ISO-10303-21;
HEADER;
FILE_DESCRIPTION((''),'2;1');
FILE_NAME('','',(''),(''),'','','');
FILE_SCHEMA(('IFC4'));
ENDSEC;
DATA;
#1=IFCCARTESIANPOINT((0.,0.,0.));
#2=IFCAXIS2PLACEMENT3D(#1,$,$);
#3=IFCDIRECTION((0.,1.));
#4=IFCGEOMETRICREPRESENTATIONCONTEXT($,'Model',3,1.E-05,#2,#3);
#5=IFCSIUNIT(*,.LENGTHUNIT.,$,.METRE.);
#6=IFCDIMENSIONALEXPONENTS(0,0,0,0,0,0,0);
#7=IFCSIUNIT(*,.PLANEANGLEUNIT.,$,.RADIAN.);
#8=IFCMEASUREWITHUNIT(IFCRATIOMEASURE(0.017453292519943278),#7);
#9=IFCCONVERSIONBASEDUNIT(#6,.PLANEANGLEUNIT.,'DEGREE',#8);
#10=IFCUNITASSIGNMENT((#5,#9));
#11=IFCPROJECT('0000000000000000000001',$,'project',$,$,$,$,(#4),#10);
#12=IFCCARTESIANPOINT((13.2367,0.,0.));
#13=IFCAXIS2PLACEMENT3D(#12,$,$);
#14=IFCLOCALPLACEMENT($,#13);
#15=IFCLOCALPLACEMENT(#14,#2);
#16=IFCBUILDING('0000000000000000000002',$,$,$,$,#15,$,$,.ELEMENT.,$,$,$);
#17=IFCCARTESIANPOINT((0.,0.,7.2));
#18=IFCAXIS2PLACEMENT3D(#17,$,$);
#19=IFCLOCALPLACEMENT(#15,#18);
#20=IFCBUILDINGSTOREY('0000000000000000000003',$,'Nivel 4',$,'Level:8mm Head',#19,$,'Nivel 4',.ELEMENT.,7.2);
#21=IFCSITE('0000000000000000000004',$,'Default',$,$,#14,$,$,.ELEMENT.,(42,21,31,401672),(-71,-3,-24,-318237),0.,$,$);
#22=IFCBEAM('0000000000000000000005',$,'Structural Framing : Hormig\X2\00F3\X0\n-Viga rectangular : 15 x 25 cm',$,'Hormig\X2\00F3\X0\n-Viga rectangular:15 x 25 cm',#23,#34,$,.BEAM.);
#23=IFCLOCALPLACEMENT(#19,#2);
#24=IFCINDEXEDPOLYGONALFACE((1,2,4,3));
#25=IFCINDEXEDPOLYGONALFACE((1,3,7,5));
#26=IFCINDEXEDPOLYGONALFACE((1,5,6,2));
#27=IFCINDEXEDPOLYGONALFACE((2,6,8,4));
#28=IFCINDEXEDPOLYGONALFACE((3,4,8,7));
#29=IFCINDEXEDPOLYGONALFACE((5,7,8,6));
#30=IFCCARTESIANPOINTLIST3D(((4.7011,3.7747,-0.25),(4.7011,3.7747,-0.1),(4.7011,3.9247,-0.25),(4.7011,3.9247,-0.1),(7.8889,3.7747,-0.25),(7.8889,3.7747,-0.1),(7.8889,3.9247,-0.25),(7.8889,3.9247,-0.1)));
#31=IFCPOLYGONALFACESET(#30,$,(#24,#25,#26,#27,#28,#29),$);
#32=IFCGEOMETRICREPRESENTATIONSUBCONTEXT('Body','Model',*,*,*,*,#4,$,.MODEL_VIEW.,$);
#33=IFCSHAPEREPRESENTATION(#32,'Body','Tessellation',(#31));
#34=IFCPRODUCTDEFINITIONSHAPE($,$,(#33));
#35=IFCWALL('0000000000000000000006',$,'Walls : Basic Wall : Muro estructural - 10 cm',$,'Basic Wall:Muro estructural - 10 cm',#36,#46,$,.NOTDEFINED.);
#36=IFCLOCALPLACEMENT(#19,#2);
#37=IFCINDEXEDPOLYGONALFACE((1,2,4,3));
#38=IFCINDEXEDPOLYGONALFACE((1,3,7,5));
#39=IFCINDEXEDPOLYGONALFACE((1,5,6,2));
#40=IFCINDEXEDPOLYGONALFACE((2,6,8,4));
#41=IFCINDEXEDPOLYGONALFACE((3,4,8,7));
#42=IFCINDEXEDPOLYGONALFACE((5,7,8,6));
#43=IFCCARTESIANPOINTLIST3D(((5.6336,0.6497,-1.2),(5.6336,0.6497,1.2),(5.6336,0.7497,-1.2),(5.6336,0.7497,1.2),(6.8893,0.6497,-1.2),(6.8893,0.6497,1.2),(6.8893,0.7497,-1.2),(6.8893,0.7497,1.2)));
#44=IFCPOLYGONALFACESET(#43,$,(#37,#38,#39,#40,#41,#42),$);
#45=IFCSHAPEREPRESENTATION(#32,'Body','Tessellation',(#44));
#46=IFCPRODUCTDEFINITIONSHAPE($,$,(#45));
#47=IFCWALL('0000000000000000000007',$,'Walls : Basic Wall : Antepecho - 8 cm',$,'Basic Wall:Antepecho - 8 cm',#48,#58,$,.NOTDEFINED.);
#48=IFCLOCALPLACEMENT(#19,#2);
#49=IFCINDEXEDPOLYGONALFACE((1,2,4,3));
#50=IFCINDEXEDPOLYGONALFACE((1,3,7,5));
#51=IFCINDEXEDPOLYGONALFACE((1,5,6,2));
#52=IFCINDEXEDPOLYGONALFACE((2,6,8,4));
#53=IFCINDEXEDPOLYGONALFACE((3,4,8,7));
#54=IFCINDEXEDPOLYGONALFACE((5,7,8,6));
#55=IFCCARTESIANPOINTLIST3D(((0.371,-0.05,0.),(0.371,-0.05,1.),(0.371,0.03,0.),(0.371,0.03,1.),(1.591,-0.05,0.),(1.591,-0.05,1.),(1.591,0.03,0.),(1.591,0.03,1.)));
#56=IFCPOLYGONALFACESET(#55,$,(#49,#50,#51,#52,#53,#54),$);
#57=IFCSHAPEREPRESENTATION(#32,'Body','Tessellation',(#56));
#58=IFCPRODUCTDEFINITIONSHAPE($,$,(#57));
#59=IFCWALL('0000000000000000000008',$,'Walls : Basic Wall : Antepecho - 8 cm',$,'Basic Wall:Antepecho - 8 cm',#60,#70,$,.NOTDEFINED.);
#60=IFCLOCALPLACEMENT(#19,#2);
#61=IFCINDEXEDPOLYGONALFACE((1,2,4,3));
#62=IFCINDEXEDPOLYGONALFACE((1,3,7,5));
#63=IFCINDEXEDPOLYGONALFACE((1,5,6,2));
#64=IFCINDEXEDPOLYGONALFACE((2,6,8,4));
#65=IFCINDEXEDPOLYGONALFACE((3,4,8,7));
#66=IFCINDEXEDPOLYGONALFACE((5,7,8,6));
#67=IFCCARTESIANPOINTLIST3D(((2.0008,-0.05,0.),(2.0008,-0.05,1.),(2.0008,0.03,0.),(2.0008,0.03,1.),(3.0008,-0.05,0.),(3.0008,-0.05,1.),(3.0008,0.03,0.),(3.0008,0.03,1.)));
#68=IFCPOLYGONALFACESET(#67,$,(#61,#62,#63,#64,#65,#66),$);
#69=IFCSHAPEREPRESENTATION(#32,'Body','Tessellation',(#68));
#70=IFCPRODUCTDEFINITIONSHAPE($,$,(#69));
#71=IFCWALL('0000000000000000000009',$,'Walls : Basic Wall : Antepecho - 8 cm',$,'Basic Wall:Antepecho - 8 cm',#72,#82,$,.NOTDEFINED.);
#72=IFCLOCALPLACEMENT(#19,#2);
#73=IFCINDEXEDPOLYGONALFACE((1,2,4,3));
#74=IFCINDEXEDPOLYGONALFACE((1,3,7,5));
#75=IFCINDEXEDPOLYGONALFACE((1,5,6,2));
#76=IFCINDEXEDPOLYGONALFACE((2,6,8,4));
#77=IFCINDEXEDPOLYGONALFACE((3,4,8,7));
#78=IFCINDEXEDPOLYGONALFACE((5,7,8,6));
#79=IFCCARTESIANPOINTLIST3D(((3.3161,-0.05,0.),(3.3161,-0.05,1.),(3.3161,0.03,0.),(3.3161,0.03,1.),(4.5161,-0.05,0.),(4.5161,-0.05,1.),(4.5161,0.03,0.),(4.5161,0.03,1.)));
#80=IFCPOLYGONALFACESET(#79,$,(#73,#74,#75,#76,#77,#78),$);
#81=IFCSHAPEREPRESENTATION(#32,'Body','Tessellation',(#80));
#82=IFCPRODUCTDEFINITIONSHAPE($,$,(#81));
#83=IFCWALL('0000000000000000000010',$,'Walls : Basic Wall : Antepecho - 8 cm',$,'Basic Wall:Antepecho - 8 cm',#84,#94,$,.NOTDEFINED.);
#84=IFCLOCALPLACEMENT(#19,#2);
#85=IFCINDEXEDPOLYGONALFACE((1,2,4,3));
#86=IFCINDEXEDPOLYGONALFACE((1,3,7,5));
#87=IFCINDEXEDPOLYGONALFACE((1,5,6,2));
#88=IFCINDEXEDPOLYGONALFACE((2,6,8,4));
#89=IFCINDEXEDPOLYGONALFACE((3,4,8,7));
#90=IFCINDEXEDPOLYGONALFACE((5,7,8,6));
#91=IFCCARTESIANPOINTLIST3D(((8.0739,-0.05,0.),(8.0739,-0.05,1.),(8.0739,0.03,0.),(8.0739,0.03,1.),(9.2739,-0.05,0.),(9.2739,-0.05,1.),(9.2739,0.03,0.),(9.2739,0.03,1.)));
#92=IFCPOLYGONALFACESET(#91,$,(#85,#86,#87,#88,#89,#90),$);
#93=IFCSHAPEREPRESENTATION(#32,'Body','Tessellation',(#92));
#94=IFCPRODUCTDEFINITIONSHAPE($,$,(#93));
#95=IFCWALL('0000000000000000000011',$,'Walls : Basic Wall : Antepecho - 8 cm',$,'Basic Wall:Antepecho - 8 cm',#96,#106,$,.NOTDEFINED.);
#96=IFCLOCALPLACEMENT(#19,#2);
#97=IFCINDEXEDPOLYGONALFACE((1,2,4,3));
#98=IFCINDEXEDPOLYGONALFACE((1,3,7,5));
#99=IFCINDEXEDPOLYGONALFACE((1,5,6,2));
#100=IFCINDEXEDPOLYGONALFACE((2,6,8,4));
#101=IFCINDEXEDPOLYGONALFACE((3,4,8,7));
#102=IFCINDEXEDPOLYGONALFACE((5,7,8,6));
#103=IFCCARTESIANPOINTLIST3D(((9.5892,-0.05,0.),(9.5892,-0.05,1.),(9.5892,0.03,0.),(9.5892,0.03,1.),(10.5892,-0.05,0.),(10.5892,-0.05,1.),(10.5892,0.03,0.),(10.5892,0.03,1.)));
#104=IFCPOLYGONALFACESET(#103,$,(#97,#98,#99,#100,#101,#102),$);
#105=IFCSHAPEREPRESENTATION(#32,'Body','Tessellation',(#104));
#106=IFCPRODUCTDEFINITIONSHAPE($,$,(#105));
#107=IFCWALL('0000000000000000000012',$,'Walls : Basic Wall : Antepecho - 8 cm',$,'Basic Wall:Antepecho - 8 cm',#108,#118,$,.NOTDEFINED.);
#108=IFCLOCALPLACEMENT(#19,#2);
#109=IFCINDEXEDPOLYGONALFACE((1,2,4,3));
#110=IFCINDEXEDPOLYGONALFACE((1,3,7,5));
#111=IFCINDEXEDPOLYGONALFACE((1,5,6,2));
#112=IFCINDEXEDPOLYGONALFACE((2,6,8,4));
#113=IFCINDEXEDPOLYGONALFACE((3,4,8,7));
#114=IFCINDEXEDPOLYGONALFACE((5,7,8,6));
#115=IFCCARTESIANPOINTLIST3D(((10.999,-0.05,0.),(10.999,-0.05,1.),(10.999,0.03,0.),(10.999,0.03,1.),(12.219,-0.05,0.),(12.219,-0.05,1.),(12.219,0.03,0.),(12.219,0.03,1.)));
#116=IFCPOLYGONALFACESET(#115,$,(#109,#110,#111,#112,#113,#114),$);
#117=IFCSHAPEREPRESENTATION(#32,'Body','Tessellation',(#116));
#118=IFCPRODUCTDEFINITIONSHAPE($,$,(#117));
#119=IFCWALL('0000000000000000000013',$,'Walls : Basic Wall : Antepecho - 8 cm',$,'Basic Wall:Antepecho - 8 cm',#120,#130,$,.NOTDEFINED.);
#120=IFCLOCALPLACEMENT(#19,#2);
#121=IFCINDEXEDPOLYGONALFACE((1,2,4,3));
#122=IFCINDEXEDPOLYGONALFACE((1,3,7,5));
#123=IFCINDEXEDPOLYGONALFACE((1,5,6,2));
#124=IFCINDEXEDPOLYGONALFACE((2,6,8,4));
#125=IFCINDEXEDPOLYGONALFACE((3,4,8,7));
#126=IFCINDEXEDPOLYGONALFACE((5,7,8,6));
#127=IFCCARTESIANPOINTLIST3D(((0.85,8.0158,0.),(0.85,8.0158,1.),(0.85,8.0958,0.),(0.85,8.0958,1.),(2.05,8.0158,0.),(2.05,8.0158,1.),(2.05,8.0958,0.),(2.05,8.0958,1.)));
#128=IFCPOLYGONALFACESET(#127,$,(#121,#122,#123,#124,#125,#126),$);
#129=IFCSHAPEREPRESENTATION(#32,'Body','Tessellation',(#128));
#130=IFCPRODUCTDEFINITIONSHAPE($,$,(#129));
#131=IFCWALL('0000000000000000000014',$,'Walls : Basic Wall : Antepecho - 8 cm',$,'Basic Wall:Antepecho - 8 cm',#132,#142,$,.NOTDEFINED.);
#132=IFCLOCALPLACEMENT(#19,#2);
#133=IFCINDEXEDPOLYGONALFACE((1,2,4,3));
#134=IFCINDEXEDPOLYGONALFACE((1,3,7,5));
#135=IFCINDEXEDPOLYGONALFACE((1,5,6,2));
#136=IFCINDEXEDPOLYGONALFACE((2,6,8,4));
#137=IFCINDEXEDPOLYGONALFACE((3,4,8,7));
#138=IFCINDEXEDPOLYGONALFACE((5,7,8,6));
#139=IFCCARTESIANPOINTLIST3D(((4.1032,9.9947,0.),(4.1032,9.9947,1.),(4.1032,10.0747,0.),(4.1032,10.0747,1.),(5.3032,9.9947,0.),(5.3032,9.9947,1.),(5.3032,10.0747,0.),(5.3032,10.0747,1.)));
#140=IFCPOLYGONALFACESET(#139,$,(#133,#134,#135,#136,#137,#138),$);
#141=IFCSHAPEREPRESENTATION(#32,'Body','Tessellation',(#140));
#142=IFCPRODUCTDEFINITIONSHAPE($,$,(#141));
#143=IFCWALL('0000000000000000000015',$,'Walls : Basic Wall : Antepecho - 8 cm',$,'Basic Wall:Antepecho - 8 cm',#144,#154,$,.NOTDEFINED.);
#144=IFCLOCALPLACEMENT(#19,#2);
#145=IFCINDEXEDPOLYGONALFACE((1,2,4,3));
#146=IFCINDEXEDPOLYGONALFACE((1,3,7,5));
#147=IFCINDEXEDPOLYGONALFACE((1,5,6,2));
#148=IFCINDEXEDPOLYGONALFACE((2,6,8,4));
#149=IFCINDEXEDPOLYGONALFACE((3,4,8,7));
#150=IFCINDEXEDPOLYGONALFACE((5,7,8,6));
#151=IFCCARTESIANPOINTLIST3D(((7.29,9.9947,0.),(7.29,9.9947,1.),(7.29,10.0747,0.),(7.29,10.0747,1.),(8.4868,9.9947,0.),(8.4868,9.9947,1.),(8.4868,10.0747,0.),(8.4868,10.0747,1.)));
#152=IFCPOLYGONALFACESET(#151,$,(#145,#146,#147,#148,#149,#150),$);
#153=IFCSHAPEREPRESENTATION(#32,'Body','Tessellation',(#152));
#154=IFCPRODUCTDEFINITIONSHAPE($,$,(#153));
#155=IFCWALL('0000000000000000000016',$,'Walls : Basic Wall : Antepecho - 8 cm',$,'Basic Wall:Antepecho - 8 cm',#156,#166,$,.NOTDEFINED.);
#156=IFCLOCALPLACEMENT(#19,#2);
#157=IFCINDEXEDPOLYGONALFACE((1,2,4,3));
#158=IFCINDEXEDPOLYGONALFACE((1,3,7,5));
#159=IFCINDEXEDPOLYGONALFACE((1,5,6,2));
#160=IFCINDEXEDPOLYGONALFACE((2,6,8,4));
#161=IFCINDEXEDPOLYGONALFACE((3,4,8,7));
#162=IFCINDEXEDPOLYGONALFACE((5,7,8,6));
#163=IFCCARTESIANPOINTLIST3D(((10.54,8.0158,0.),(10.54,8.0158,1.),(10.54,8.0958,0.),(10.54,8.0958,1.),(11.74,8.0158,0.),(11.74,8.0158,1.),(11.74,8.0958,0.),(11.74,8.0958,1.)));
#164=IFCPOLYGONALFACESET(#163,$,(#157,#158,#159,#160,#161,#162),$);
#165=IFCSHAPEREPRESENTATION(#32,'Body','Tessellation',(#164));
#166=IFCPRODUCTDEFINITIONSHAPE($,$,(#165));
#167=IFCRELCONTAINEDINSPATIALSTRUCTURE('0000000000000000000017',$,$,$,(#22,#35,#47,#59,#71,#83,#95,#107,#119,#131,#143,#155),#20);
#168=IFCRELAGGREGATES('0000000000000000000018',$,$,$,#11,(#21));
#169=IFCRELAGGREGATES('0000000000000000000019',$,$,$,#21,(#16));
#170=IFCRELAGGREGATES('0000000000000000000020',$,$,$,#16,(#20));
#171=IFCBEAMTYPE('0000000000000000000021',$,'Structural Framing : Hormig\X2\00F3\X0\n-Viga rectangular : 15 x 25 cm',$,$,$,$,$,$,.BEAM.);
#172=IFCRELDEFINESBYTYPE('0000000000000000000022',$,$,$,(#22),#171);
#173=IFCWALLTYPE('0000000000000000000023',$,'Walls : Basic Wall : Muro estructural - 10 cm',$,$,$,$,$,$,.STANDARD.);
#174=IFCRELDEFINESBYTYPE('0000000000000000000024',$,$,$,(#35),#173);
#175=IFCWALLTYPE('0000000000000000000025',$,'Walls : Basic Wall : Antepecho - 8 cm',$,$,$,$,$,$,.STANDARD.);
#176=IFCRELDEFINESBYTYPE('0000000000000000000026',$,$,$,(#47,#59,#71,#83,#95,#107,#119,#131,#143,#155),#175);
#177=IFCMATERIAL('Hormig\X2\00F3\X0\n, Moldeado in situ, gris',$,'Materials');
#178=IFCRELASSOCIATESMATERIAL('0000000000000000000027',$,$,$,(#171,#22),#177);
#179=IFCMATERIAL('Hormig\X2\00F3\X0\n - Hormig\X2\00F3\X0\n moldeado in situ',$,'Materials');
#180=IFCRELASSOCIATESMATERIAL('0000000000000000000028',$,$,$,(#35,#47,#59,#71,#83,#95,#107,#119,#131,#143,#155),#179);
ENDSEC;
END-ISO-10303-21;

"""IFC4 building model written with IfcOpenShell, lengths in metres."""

from ifc_helpers import new_model, entity, si_unit, converted_unit, direction, frame, origin, place, context, subcontext, project, spatial, indexed_curve, outline, extrude, source, transform, mapped, material, type_object, type_shapes, element, save


model = new_model("IFC4")

# Units and contexts
model_context = context("Model", 3, precision=1e-05, world=origin(), true_north=direction((0.0, 1.0)))
body_context = subcontext(model_context, "Body", "Model", "MODEL_VIEW")
ifc_project = project(units=[si_unit("LENGTHUNIT", "METRE"), converted_unit("PLANEANGLEUNIT", "DEGREE", entity("IfcRatioMeasure", 0.017453292519943278), si_unit("PLANEANGLEUNIT", "RADIAN"), dimensions=[0, 0, 0, 0, 0, 0, 0])], contexts=[model_context])

# Site, building, storey
site_placement = place(None, frame((13.2367, 0.0, 0.0)))
site = spatial("IfcSite", under=ifc_project, at=site_placement, Name="Default", CompositionType="ELEMENT", RefLatitude=(42, 21, 31, 401672), RefLongitude=(-71, -3, -24, -318237), RefElevation=0.0)
building_placement = place(site_placement, origin())
building = spatial("IfcBuilding", under=site, at=building_placement, CompositionType="ELEMENT")
storey_placement = place(building_placement, frame((0.0, 0.0, 7.2)))
storey = spatial("IfcBuildingStorey", under=building, at=storey_placement, Name="Nivel 4", ObjectType="Level:8mm Head", LongName="Nivel 4", CompositionType="ELEMENT", Elevation=7.2)

# Beam
ifc_material_1 = material(Name="Hormigón, Moldeado in situ, gris", Category="Materials")
beam_type_1 = type_object("IfcBeamType", Name="Structural Framing : Hormigón-Viga rectangular : 15 x 25 cm", PredefinedType="BEAM", material=ifc_material_1)
shared_shape_1 = source(origin(), body_context, "Body", "SweptSolid", [
    extrude(outline(indexed_curve([(-0.075, -0.075), (0.075, -0.075), (0.075, 0.075), (-0.075, 0.075), (-0.075, -0.075)], self_intersect=False)), frame((4.7011, 3.8497, 7.025), z_axis=(1.0, 0.0, 0.0), x_axis=(0.0, 0.0, -1.0)), (0.0, 0.0, 1.0), 3.1878),
])
type_shapes(beam_type_1, [shared_shape_1])
beam_1_placement = place(storey_placement, frame((0.0, 0.0, -7.2)))
element("IfcBeam", 1, at=beam_1_placement, inside=storey, type_object=beam_type_1, material=ifc_material_1, Name="Structural Framing : Hormigón-Viga rectangular : 15 x 25 cm", ObjectType="Hormigón-Viga rectangular:15 x 25 cm", PredefinedType="BEAM", context=body_context, shape_type="MappedRepresentation", body=[
    mapped(shared_shape_1, transform((0.0, 0.0, 0.0), scale=1.0)),
])

# Shared definitions
ifc_material_2 = material(Name="Hormigón - Hormigón moldeado in situ", Category="Materials")

# Walls
wall_type_1 = type_object("IfcWallType", Name="Walls : Basic Wall : Muro estructural - 10 cm", PredefinedType="STANDARD")
wall_1_placement = place(storey_placement, frame((5.6336, 0.6997, -1.2)))
element("IfcWall", 2, at=wall_1_placement, inside=storey, type_object=wall_type_1, material=ifc_material_2, Name="Walls : Basic Wall : Muro estructural - 10 cm", ObjectType="Basic Wall:Muro estructural - 10 cm", PredefinedType="NOTDEFINED", context=body_context, shape_type="SweptSolid", body=[
    extrude(outline(indexed_curve([(1.2557, 0.05), (0.0, 0.05), (0.0, -0.05), (1.2557, -0.05), (1.2557, 0.05)], self_intersect=False)), origin(), (0.0, 0.0, 1.0), 2.4),
])
wall_type_2 = type_object("IfcWallType", Name="Walls : Basic Wall : Antepecho - 8 cm", PredefinedType="STANDARD")
wall_2_placement = place(storey_placement, frame((0.371, -0.01, 0.0)))
element("IfcWall", 3, at=wall_2_placement, inside=storey, type_object=wall_type_2, material=ifc_material_2, Name="Walls : Basic Wall : Antepecho - 8 cm", ObjectType="Basic Wall:Antepecho - 8 cm", PredefinedType="NOTDEFINED", context=body_context, shape_type="SweptSolid", body=[
    extrude(outline(indexed_curve([(1.22, 0.04), (0.0, 0.04), (0.0, -0.04), (1.22, -0.04), (1.22, 0.04)], self_intersect=False)), origin(), (0.0, 0.0, 1.0), 1.0),
])
wall_3_placement = place(storey_placement, frame((2.0008, -0.01, 0.0)))
element("IfcWall", 4, at=wall_3_placement, inside=storey, type_object=wall_type_2, material=ifc_material_2, Name="Walls : Basic Wall : Antepecho - 8 cm", ObjectType="Basic Wall:Antepecho - 8 cm", PredefinedType="NOTDEFINED", context=body_context, shape_type="SweptSolid", body=[
    extrude(outline(indexed_curve([(1.0, 0.04), (0.0, 0.04), (0.0, -0.04), (1.0, -0.04), (1.0, 0.04)], self_intersect=False)), origin(), (0.0, 0.0, 1.0), 1.0),
])
wall_4_placement = place(storey_placement, frame((3.3161, -0.01, 0.0)))
element("IfcWall", 5, at=wall_4_placement, inside=storey, type_object=wall_type_2, material=ifc_material_2, Name="Walls : Basic Wall : Antepecho - 8 cm", ObjectType="Basic Wall:Antepecho - 8 cm", PredefinedType="NOTDEFINED", context=body_context, shape_type="SweptSolid", body=[
    extrude(outline(indexed_curve([(1.2, 0.04), (0.0, 0.04), (0.0, -0.04), (1.2, -0.04), (1.2, 0.04)], self_intersect=False)), origin(), (0.0, 0.0, 1.0), 1.0),
])
wall_5_placement = place(storey_placement, frame((8.0739, -0.01, 0.0)))
element("IfcWall", 6, at=wall_5_placement, inside=storey, type_object=wall_type_2, material=ifc_material_2, Name="Walls : Basic Wall : Antepecho - 8 cm", ObjectType="Basic Wall:Antepecho - 8 cm", PredefinedType="NOTDEFINED", context=body_context, shape_type="SweptSolid", body=[
    extrude(outline(indexed_curve([(1.2, 0.04), (0.0, 0.04), (0.0, -0.04), (1.2, -0.04), (1.2, 0.04)], self_intersect=False)), origin(), (0.0, 0.0, 1.0), 1.0),
])
wall_6_placement = place(storey_placement, frame((9.5892, -0.01, 0.0)))
element("IfcWall", 7, at=wall_6_placement, inside=storey, type_object=wall_type_2, material=ifc_material_2, Name="Walls : Basic Wall : Antepecho - 8 cm", ObjectType="Basic Wall:Antepecho - 8 cm", PredefinedType="NOTDEFINED", context=body_context, shape_type="SweptSolid", body=[
    extrude(outline(indexed_curve([(1.0, 0.04), (0.0, 0.04), (0.0, -0.04), (1.0, -0.04), (1.0, 0.04)], self_intersect=False)), origin(), (0.0, 0.0, 1.0), 1.0),
])
wall_7_placement = place(storey_placement, frame((10.999, -0.01, 0.0)))
element("IfcWall", 8, at=wall_7_placement, inside=storey, type_object=wall_type_2, material=ifc_material_2, Name="Walls : Basic Wall : Antepecho - 8 cm", ObjectType="Basic Wall:Antepecho - 8 cm", PredefinedType="NOTDEFINED", context=body_context, shape_type="SweptSolid", body=[
    extrude(outline(indexed_curve([(1.22, 0.04), (0.0, 0.04), (0.0, -0.04), (1.22, -0.04), (1.22, 0.04)], self_intersect=False)), origin(), (0.0, 0.0, 1.0), 1.0),
])
wall_8_placement = place(storey_placement, frame((2.05, 8.0558, 0.0), z_axis=(0.0, 0.0, 1.0), x_axis=(-1.0, 0.0, 0.0)))
element("IfcWall", 9, at=wall_8_placement, inside=storey, type_object=wall_type_2, material=ifc_material_2, Name="Walls : Basic Wall : Antepecho - 8 cm", ObjectType="Basic Wall:Antepecho - 8 cm", PredefinedType="NOTDEFINED", context=body_context, shape_type="SweptSolid", body=[
    extrude(outline(indexed_curve([(1.2, 0.04), (0.0, 0.04), (0.0, -0.04), (1.2, -0.04), (1.2, 0.04)], self_intersect=False)), origin(), (0.0, 0.0, 1.0), 1.0),
])
wall_9_placement = place(storey_placement, frame((5.3032, 10.0347, 0.0), z_axis=(0.0, 0.0, 1.0), x_axis=(-1.0, 0.0, 0.0)))
element("IfcWall", 10, at=wall_9_placement, inside=storey, type_object=wall_type_2, material=ifc_material_2, Name="Walls : Basic Wall : Antepecho - 8 cm", ObjectType="Basic Wall:Antepecho - 8 cm", PredefinedType="NOTDEFINED", context=body_context, shape_type="SweptSolid", body=[
    extrude(outline(indexed_curve([(1.2, 0.04), (0.0, 0.04), (0.0, -0.04), (1.2, -0.04), (1.2, 0.04)], self_intersect=False)), origin(), (0.0, 0.0, 1.0), 1.0),
])
wall_10_placement = place(storey_placement, frame((8.4868, 10.0347, 0.0), z_axis=(0.0, 0.0, 1.0), x_axis=(-1.0, 0.0, 0.0)))
element("IfcWall", 11, at=wall_10_placement, inside=storey, type_object=wall_type_2, material=ifc_material_2, Name="Walls : Basic Wall : Antepecho - 8 cm", ObjectType="Basic Wall:Antepecho - 8 cm", PredefinedType="NOTDEFINED", context=body_context, shape_type="SweptSolid", body=[
    extrude(outline(indexed_curve([(1.1968, 0.04), (0.0, 0.04), (0.0, -0.04), (1.1968, -0.04), (1.1968, 0.04)], self_intersect=False)), origin(), (0.0, 0.0, 1.0), 1.0),
])
wall_11_placement = place(storey_placement, frame((11.74, 8.0558, 0.0), z_axis=(0.0, 0.0, 1.0), x_axis=(-1.0, 0.0, 0.0)))
element("IfcWall", 12, at=wall_11_placement, inside=storey, type_object=wall_type_2, material=ifc_material_2, Name="Walls : Basic Wall : Antepecho - 8 cm", ObjectType="Basic Wall:Antepecho - 8 cm", PredefinedType="NOTDEFINED", context=body_context, shape_type="SweptSolid", body=[
    extrude(outline(indexed_curve([(1.2, 0.04), (0.0, 0.04), (0.0, -0.04), (1.2, -0.04), (1.2, 0.04)], self_intersect=False)), origin(), (0.0, 0.0, 1.0), 1.0),
])

save(model, "model.ifc")
